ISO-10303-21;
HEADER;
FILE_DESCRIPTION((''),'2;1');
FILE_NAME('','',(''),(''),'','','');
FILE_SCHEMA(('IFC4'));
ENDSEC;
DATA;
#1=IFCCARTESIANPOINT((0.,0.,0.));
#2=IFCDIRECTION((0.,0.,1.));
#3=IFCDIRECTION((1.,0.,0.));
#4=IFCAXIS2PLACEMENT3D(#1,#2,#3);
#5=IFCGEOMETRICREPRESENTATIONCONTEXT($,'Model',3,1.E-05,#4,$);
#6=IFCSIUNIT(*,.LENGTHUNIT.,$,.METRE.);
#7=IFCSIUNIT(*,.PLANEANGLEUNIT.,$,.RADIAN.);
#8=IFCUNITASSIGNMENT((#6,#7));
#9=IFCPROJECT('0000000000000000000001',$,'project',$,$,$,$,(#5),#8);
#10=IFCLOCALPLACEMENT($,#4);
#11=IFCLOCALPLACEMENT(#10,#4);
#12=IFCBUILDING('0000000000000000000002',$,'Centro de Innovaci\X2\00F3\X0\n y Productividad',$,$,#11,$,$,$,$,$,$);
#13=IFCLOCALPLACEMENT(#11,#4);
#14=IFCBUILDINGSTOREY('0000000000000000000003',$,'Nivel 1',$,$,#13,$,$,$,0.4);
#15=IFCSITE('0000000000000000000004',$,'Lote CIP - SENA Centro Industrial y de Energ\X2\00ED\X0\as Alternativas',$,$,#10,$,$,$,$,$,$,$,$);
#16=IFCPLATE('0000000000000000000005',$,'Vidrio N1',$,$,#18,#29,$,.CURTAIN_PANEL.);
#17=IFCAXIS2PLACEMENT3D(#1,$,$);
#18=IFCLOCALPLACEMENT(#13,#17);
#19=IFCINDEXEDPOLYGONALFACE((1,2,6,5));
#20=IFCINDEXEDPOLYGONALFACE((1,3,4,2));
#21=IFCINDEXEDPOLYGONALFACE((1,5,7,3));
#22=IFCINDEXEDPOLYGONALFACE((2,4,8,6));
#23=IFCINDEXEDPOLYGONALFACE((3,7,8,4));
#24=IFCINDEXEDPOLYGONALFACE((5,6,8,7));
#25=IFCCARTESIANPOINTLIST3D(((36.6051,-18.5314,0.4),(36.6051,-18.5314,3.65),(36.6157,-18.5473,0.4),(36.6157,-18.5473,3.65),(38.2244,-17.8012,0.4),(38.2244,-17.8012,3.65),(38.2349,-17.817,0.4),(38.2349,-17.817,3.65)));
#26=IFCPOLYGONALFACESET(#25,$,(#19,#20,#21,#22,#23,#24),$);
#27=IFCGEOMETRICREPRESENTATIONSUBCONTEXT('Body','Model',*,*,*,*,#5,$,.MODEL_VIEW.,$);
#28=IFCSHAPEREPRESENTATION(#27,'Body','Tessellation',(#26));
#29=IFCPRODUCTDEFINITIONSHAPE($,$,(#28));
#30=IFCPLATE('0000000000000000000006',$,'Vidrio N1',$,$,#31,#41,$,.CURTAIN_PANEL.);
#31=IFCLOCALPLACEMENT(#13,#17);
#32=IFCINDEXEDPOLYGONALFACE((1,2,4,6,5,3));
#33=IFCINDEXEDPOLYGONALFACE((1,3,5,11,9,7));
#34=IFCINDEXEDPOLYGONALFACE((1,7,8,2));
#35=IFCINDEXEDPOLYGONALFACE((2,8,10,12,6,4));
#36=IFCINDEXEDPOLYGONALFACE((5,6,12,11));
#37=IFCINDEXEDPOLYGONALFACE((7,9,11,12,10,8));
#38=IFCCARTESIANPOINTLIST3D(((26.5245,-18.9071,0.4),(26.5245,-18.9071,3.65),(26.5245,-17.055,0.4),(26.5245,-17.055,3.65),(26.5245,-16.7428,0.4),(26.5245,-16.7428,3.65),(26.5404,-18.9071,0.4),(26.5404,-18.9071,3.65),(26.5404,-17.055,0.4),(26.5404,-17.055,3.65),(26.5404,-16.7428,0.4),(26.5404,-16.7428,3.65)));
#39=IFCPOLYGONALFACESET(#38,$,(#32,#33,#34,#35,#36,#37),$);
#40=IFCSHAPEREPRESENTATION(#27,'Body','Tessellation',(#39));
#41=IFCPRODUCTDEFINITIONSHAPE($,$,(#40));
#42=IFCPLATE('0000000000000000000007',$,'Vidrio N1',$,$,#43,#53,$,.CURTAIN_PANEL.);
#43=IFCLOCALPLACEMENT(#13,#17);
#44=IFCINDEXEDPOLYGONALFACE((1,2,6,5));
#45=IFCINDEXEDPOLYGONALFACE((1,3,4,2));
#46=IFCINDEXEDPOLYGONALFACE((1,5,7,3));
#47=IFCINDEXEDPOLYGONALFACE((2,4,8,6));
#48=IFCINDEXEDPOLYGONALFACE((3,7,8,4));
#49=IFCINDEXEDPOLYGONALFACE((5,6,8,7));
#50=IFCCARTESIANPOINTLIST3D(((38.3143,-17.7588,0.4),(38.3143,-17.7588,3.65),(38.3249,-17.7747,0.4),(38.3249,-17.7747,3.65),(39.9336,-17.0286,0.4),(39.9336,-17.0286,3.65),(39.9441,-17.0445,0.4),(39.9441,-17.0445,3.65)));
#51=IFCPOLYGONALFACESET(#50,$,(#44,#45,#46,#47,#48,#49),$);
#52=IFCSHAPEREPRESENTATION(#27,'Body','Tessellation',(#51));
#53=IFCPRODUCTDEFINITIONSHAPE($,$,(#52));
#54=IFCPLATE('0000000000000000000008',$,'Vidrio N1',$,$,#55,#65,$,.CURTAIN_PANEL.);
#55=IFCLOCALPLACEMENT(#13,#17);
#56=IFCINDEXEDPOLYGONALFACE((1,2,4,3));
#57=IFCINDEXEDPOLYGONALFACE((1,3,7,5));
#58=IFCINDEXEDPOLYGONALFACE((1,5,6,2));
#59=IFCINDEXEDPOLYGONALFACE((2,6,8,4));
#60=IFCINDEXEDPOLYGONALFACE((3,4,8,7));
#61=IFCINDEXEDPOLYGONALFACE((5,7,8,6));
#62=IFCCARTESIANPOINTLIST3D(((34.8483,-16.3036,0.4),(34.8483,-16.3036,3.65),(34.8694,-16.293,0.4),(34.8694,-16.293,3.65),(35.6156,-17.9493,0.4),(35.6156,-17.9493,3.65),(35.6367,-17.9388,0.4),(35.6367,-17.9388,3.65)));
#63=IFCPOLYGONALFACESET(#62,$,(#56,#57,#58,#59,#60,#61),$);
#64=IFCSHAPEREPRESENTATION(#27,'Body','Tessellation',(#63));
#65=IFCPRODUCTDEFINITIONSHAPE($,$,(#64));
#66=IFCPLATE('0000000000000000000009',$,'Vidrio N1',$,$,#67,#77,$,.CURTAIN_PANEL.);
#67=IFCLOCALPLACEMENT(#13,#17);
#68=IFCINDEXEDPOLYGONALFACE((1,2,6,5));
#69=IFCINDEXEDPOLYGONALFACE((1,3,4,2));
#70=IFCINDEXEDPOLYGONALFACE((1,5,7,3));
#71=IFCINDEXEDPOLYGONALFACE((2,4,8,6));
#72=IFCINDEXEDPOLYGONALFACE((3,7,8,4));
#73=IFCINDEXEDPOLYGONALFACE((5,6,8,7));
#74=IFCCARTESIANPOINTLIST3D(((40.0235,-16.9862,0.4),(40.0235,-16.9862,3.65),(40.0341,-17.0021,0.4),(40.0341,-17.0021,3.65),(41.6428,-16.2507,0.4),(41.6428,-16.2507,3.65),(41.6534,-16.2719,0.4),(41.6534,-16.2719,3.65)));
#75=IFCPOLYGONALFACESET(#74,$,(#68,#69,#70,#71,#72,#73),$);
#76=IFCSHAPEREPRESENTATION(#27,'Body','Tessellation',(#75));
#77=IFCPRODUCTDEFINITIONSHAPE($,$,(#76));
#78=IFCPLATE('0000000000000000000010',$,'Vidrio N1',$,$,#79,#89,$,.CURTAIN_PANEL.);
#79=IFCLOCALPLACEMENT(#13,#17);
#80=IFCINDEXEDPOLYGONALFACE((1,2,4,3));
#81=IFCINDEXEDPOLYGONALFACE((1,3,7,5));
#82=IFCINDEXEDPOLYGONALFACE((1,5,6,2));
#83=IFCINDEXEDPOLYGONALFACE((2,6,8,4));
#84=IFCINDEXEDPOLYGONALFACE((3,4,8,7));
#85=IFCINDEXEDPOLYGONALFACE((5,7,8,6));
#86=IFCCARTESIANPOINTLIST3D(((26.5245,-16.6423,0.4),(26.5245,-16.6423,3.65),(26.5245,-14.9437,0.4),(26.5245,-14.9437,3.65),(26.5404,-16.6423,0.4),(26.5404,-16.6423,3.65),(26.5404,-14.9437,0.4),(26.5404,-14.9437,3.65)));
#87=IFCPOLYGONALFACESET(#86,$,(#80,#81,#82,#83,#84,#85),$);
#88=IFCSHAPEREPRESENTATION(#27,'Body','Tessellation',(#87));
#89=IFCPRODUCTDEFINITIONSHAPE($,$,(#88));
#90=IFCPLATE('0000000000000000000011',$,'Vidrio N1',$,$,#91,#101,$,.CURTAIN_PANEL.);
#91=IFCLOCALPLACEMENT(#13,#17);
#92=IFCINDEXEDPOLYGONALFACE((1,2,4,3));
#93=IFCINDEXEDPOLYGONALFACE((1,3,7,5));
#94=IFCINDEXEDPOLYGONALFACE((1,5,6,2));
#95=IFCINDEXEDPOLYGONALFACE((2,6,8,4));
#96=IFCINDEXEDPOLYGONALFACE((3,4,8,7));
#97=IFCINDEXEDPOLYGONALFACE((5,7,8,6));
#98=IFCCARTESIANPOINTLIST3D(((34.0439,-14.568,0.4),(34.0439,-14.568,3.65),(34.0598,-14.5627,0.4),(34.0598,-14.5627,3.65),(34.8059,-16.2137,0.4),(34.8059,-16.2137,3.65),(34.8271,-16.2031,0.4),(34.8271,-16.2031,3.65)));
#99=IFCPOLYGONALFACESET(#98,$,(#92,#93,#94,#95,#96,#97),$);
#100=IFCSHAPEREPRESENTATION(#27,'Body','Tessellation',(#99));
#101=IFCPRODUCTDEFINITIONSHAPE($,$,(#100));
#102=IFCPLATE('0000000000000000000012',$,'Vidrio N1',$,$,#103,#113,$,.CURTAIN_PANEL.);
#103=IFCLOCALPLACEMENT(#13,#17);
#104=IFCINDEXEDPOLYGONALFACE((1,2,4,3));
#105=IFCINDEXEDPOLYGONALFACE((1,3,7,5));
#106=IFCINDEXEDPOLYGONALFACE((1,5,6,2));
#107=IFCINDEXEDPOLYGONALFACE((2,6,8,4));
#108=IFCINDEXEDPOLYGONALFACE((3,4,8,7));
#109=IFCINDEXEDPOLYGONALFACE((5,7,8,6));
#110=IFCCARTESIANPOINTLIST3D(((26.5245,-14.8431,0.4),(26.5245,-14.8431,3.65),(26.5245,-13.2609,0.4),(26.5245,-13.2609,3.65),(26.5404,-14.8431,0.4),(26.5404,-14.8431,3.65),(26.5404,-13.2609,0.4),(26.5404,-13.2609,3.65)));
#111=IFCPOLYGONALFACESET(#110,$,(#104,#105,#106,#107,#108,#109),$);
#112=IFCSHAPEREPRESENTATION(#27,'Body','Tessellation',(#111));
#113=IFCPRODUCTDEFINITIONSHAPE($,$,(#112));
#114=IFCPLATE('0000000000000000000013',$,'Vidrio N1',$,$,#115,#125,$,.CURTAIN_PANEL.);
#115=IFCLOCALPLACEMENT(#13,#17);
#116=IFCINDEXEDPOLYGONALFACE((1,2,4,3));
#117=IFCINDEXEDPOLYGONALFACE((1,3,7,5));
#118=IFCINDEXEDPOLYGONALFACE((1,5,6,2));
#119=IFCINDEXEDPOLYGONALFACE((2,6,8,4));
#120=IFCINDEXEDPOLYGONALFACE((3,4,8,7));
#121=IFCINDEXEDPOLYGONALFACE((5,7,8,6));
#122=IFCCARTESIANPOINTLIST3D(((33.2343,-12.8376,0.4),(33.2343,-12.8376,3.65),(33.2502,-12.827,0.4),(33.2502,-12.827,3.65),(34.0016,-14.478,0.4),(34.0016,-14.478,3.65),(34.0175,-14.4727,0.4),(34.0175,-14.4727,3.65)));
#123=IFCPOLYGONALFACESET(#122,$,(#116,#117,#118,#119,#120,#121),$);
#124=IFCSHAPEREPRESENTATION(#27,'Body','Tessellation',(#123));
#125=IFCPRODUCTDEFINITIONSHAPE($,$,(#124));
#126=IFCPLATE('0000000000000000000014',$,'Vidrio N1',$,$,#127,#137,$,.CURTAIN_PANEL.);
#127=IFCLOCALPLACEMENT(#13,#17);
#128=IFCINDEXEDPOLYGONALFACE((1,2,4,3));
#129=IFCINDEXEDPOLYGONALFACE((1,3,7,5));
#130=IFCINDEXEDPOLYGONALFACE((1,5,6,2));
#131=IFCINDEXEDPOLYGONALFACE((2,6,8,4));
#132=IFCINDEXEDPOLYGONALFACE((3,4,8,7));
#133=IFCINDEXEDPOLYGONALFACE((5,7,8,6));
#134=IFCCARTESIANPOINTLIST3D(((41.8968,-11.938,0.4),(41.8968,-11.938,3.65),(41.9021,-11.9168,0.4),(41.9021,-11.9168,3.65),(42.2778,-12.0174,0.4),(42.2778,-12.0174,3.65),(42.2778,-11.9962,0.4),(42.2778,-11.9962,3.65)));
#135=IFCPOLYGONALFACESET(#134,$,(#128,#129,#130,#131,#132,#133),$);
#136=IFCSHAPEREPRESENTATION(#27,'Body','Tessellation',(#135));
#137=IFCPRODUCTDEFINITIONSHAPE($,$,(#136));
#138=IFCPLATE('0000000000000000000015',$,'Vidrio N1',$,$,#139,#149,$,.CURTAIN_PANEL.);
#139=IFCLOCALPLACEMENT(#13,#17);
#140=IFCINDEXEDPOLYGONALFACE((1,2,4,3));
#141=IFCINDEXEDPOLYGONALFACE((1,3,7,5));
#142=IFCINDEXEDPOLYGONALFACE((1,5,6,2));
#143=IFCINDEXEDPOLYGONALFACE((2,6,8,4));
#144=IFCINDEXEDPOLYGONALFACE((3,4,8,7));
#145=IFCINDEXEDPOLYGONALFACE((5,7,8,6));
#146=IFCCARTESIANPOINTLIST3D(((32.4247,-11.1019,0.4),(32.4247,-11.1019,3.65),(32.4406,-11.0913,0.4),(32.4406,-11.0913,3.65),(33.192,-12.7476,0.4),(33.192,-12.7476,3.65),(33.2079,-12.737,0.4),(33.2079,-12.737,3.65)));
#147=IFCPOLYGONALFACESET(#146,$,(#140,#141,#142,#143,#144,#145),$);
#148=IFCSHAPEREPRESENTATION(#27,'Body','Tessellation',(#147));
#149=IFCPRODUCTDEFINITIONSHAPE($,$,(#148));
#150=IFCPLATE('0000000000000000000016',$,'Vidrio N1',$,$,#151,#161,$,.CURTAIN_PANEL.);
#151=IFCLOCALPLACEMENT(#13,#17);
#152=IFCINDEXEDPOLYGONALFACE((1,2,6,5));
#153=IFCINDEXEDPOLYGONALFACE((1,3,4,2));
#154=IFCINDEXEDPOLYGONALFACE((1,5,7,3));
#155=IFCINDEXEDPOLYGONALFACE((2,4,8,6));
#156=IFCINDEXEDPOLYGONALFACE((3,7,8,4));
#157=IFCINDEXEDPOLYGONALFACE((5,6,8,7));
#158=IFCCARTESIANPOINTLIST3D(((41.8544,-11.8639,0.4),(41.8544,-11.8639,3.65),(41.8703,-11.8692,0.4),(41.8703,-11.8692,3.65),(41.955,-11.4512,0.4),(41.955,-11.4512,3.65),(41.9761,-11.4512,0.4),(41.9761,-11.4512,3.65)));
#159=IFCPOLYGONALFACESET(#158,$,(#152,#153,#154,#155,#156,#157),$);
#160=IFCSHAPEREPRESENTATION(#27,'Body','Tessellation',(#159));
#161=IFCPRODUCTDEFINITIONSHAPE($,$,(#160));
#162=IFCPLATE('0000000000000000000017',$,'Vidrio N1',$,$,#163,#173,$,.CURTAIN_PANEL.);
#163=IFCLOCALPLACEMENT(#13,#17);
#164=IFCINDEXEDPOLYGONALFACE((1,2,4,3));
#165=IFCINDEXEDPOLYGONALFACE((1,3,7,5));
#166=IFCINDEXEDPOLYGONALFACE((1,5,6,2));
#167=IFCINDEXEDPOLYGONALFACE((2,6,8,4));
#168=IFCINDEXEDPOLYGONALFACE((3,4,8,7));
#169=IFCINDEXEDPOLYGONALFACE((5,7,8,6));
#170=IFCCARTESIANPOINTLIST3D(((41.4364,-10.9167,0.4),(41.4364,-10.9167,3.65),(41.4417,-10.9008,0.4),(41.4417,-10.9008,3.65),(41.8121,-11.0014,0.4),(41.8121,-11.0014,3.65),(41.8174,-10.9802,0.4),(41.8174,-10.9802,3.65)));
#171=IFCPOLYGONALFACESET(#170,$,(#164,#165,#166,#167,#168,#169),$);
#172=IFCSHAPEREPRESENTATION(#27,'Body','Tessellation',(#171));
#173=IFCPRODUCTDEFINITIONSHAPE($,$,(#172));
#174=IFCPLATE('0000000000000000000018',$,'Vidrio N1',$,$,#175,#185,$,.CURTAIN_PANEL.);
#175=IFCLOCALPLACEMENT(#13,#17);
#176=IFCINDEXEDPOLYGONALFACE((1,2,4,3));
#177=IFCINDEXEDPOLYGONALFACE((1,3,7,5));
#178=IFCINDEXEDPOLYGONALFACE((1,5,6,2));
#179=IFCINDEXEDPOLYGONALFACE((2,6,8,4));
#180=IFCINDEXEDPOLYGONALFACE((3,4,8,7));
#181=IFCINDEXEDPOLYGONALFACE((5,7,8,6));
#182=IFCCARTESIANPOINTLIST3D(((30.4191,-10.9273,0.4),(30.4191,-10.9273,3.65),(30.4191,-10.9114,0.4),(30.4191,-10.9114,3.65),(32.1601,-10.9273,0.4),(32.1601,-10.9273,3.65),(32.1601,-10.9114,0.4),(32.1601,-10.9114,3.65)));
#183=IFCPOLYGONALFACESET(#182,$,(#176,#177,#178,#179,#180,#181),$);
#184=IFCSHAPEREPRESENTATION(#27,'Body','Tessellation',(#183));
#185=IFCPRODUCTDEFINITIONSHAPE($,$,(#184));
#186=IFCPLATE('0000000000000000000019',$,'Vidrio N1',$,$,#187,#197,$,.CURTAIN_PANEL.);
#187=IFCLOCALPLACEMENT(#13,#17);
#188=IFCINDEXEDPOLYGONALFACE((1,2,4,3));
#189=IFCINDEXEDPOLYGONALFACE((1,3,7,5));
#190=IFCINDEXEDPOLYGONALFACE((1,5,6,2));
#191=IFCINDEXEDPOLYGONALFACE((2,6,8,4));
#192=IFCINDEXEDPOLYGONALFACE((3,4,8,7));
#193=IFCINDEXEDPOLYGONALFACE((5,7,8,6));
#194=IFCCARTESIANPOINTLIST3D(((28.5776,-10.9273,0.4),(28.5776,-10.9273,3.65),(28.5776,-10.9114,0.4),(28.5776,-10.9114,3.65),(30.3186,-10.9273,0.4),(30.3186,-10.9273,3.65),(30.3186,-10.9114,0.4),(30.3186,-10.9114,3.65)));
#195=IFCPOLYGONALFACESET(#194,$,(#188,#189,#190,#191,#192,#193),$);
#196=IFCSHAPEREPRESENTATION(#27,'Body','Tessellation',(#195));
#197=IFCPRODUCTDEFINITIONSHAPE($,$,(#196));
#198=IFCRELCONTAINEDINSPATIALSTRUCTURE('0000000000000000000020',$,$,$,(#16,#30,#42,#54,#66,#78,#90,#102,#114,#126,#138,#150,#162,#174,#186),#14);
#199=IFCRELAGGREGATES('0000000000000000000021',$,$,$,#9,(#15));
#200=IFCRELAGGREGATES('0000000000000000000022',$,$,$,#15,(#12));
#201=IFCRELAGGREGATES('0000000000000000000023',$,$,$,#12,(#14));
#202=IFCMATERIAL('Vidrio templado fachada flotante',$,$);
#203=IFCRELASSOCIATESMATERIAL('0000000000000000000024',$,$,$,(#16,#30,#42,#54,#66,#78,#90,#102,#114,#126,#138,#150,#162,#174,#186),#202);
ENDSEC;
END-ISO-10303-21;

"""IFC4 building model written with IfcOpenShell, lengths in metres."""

from ifc_helpers import new_model, si_unit, frame, origin_with_axes, place, context, subcontext, project, spatial, polyline, outline, extrude, material, element, save


model = new_model("IFC4")

# Units and contexts
model_context = context("Model", 3, precision=1e-05, world=origin_with_axes())
body_context = subcontext(model_context, "Body", "Model", "MODEL_VIEW")
ifc_project = project(units=[si_unit("LENGTHUNIT", "METRE"), si_unit("PLANEANGLEUNIT", "RADIAN")], contexts=[model_context])

# Site, building, storey
site_placement = place(None, origin_with_axes())
site = spatial("IfcSite", under=ifc_project, at=site_placement, Name="Lote CIP - SENA Centro Industrial y de Energías Alternativas")
building_placement = place(site_placement, origin_with_axes())
building = spatial("IfcBuilding", under=site, at=building_placement, Name="Centro de Innovación y Productividad")
storey_placement = place(building_placement, origin_with_axes())
storey = spatial("IfcBuildingStorey", under=building, at=storey_placement, Name="Nivel 1", Elevation=0.4)

# Plates
ifc_material = material(Name="Vidrio templado fachada flotante")
plate_1_placement = place(storey_placement, origin_with_axes())
element("IfcPlate", 1, at=plate_1_placement, inside=storey, material=ifc_material, Name="Vidrio N1", PredefinedType="CURTAIN_PANEL", context=body_context, shape_type="SweptSolid", body=[
    extrude(outline(polyline([(38.2349, -17.817), (36.6157, -18.5473), (36.6051, -18.5314), (38.2244, -17.8012), (38.2349, -17.817)])), frame((0.0, 0.0, 0.4)), (0.0, 0.0, 1.0), 3.25),
])
plate_2_placement = place(storey_placement, origin_with_axes())
element("IfcPlate", 2, at=plate_2_placement, inside=storey, material=ifc_material, Name="Vidrio N1", PredefinedType="CURTAIN_PANEL", context=body_context, shape_type="SweptSolid", body=[
    extrude(outline(polyline([(26.5404, -17.055), (26.5404, -18.9071), (26.5245, -18.9071), (26.5245, -17.055), (26.5245, -16.7428), (26.5404, -16.7428), (26.5404, -17.055)])), frame((0.0, 0.0, 0.4)), (0.0, 0.0, 1.0), 3.25),
])
plate_3_placement = place(storey_placement, origin_with_axes())
element("IfcPlate", 3, at=plate_3_placement, inside=storey, material=ifc_material, Name="Vidrio N1", PredefinedType="CURTAIN_PANEL", context=body_context, shape_type="SweptSolid", body=[
    extrude(outline(polyline([(38.3249, -17.7747), (38.3143, -17.7588), (39.9336, -17.0286), (39.9441, -17.0445), (38.3249, -17.7747)])), frame((0.0, 0.0, 0.4)), (0.0, 0.0, 1.0), 3.25),
])
plate_4_placement = place(storey_placement, origin_with_axes())
element("IfcPlate", 4, at=plate_4_placement, inside=storey, material=ifc_material, Name="Vidrio N1", PredefinedType="CURTAIN_PANEL", context=body_context, shape_type="SweptSolid", body=[
    extrude(outline(polyline([(35.6367, -17.9387), (35.6156, -17.9493), (34.8483, -16.3036), (34.8694, -16.293), (35.6367, -17.9387)])), frame((0.0, 0.0, 0.4)), (0.0, 0.0, 1.0), 3.25),
])
plate_5_placement = place(storey_placement, origin_with_axes())
element("IfcPlate", 5, at=plate_5_placement, inside=storey, material=ifc_material, Name="Vidrio N1", PredefinedType="CURTAIN_PANEL", context=body_context, shape_type="SweptSolid", body=[
    extrude(outline(polyline([(41.6534, -16.2719), (40.0341, -17.0021), (40.0235, -16.9862), (41.6428, -16.2507), (41.6534, -16.2719)])), frame((0.0, 0.0, 0.4)), (0.0, 0.0, 1.0), 3.25),
])
plate_6_placement = place(storey_placement, origin_with_axes())
element("IfcPlate", 6, at=plate_6_placement, inside=storey, material=ifc_material, Name="Vidrio N1", PredefinedType="CURTAIN_PANEL", context=body_context, shape_type="SweptSolid", body=[
    extrude(outline(polyline([(26.5404, -14.9437), (26.5404, -16.6423), (26.5245, -16.6423), (26.5245, -14.9437), (26.5404, -14.9437)])), frame((0.0, 0.0, 0.4)), (0.0, 0.0, 1.0), 3.25),
])
plate_7_placement = place(storey_placement, origin_with_axes())
element("IfcPlate", 7, at=plate_7_placement, inside=storey, material=ifc_material, Name="Vidrio N1", PredefinedType="CURTAIN_PANEL", context=body_context, shape_type="SweptSolid", body=[
    extrude(outline(polyline([(34.8271, -16.2031), (34.8059, -16.2137), (34.0439, -14.568), (34.0598, -14.5627), (34.8271, -16.2031)])), frame((0.0, 0.0, 0.4)), (0.0, 0.0, 1.0), 3.25),
])
plate_8_placement = place(storey_placement, origin_with_axes())
element("IfcPlate", 8, at=plate_8_placement, inside=storey, material=ifc_material, Name="Vidrio N1", PredefinedType="CURTAIN_PANEL", context=body_context, shape_type="SweptSolid", body=[
    extrude(outline(polyline([(26.5404, -13.2609), (26.5404, -14.8431), (26.5245, -14.8431), (26.5245, -13.2609), (26.5404, -13.2609)])), frame((0.0, 0.0, 0.4)), (0.0, 0.0, 1.0), 3.25),
])
plate_9_placement = place(storey_placement, origin_with_axes())
element("IfcPlate", 9, at=plate_9_placement, inside=storey, material=ifc_material, Name="Vidrio N1", PredefinedType="CURTAIN_PANEL", context=body_context, shape_type="SweptSolid", body=[
    extrude(outline(polyline([(34.0175, -14.4727), (34.0016, -14.478), (33.2343, -12.8376), (33.2502, -12.827), (34.0175, -14.4727)])), frame((0.0, 0.0, 0.4)), (0.0, 0.0, 1.0), 3.25),
])
plate_10_placement = place(storey_placement, origin_with_axes())
element("IfcPlate", 10, at=plate_10_placement, inside=storey, material=ifc_material, Name="Vidrio N1", PredefinedType="CURTAIN_PANEL", context=body_context, shape_type="SweptSolid", body=[
    extrude(outline(polyline([(42.2778, -12.0174), (41.8968, -11.938), (41.9021, -11.9168), (42.2778, -11.9962), (42.2778, -12.0174)])), frame((0.0, 0.0, 0.4)), (0.0, 0.0, 1.0), 3.25),
])
plate_11_placement = place(storey_placement, origin_with_axes())
element("IfcPlate", 11, at=plate_11_placement, inside=storey, material=ifc_material, Name="Vidrio N1", PredefinedType="CURTAIN_PANEL", context=body_context, shape_type="SweptSolid", body=[
    extrude(outline(polyline([(32.4247, -11.1019), (32.4406, -11.0913), (33.2079, -12.737), (33.192, -12.7476), (32.4247, -11.1019)])), frame((0.0, 0.0, 0.4)), (0.0, 0.0, 1.0), 3.25),
])
plate_12_placement = place(storey_placement, origin_with_axes())
element("IfcPlate", 12, at=plate_12_placement, inside=storey, material=ifc_material, Name="Vidrio N1", PredefinedType="CURTAIN_PANEL", context=body_context, shape_type="SweptSolid", body=[
    extrude(outline(polyline([(41.8703, -11.8692), (41.8544, -11.8639), (41.955, -11.4512), (41.9761, -11.4512), (41.8703, -11.8692)])), frame((0.0, 0.0, 0.4)), (0.0, 0.0, 1.0), 3.25),
])
plate_13_placement = place(storey_placement, origin_with_axes())
element("IfcPlate", 13, at=plate_13_placement, inside=storey, material=ifc_material, Name="Vidrio N1", PredefinedType="CURTAIN_PANEL", context=body_context, shape_type="SweptSolid", body=[
    extrude(outline(polyline([(41.4364, -10.9167), (41.4417, -10.9008), (41.8174, -10.9802), (41.8121, -11.0014), (41.4364, -10.9167)])), frame((0.0, 0.0, 0.4)), (0.0, 0.0, 1.0), 3.25),
])
plate_14_placement = place(storey_placement, origin_with_axes())
element("IfcPlate", 14, at=plate_14_placement, inside=storey, material=ifc_material, Name="Vidrio N1", PredefinedType="CURTAIN_PANEL", context=body_context, shape_type="SweptSolid", body=[
    extrude(outline(polyline([(32.1601, -10.9114), (32.1601, -10.9273), (30.4191, -10.9273), (30.4191, -10.9114), (32.1601, -10.9114)])), frame((0.0, 0.0, 0.4)), (0.0, 0.0, 1.0), 3.25),
])
plate_15_placement = place(storey_placement, origin_with_axes())
element("IfcPlate", 15, at=plate_15_placement, inside=storey, material=ifc_material, Name="Vidrio N1", PredefinedType="CURTAIN_PANEL", context=body_context, shape_type="SweptSolid", body=[
    extrude(outline(polyline([(28.5776, -10.9273), (28.5776, -10.9114), (30.3186, -10.9114), (30.3186, -10.9273), (28.5776, -10.9273)])), frame((0.0, 0.0, 0.4)), (0.0, 0.0, 1.0), 3.25),
])

save(model, "model.ifc")
